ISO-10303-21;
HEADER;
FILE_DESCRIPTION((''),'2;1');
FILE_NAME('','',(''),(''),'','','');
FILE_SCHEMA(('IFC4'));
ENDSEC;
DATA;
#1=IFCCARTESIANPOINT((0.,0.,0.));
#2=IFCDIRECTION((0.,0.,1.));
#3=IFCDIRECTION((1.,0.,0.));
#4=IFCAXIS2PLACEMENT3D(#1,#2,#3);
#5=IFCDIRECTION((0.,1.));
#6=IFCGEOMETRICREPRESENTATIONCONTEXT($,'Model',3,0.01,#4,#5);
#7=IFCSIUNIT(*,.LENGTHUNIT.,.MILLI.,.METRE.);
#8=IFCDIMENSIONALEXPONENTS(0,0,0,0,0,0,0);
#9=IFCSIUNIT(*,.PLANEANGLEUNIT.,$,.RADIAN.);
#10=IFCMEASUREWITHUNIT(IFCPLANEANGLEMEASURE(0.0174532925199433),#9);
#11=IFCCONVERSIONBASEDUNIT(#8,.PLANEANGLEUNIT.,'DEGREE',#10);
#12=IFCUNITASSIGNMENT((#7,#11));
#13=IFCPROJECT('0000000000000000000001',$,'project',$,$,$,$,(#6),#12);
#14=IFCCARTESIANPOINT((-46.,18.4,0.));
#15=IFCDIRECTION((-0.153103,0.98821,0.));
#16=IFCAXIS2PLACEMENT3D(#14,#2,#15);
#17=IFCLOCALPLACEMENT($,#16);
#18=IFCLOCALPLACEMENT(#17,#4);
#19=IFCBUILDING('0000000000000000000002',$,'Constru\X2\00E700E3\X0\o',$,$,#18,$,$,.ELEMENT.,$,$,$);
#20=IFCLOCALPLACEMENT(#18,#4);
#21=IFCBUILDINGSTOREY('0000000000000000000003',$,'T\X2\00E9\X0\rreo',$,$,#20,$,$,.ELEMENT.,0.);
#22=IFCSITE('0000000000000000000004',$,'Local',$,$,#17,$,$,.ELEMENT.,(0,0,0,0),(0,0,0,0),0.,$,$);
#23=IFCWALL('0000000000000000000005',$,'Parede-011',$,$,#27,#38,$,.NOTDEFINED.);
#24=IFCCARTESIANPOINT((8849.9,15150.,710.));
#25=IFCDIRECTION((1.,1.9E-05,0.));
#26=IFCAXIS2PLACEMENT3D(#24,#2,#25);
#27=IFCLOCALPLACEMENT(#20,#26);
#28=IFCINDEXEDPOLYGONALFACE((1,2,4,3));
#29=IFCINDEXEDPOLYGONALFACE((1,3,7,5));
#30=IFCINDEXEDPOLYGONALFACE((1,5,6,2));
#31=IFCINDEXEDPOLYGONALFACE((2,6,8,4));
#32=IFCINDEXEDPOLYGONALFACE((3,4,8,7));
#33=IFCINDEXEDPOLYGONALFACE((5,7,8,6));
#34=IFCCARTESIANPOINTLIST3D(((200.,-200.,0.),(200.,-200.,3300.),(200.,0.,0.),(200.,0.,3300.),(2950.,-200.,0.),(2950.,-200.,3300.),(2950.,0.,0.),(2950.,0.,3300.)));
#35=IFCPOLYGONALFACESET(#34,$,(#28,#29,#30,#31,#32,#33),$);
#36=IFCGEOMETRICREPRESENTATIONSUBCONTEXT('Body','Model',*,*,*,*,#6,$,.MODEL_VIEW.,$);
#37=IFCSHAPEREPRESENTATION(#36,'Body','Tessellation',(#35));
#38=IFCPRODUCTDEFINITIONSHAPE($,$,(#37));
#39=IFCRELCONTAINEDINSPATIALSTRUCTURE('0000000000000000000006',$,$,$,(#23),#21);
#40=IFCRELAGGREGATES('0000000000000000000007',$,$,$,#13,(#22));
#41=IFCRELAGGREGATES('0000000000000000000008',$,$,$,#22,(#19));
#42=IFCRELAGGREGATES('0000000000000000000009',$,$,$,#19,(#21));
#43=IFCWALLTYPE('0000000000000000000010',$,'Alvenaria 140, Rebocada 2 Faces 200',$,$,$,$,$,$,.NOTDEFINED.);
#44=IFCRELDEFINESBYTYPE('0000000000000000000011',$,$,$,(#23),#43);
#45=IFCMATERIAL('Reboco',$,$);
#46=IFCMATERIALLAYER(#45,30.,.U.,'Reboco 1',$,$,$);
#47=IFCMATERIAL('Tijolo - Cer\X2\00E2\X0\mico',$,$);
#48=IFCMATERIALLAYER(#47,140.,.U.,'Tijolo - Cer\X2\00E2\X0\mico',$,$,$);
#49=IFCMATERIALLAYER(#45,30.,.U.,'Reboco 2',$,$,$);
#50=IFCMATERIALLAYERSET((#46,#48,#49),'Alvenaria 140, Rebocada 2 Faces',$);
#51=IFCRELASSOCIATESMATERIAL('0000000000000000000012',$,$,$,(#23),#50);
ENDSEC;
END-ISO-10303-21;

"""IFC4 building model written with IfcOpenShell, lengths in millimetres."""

from ifc_helpers import new_model, entity, si_unit, converted_unit, direction, frame, origin_with_axes, place, context, subcontext, project, spatial, line, indexed_curve, outline, extrude, material, layer, layer_set, layer_usage, type_object, element, save


model = new_model("IFC4")

# Units and contexts
model_context = context("Model", 3, precision=0.01, world=origin_with_axes(), true_north=direction((0.0, 1.0)))
body_context = subcontext(model_context, "Body", "Model", "MODEL_VIEW")
ifc_project = project(units=[si_unit("LENGTHUNIT", "METRE", prefix="MILLI"), converted_unit("PLANEANGLEUNIT", "DEGREE", entity("IfcPlaneAngleMeasure", 0.0174532925199433), si_unit("PLANEANGLEUNIT", "RADIAN"), dimensions=[0, 0, 0, 0, 0, 0, 0])], contexts=[model_context])

# Site, building, storey
site_placement = place(None, frame((-46.0, 18.4, 0.0), z_axis=(0.0, 0.0, 1.0), x_axis=(-0.153103, 0.98821, 0.0)))
site = spatial("IfcSite", under=ifc_project, at=site_placement, Name="Local", CompositionType="ELEMENT", RefLatitude=(0, 0, 0, 0), RefLongitude=(0, 0, 0, 0), RefElevation=0.0)
building_placement = place(site_placement, origin_with_axes())
building = spatial("IfcBuilding", under=site, at=building_placement, Name="Construção", CompositionType="ELEMENT")
storey_placement = place(building_placement, origin_with_axes())
storey = spatial("IfcBuildingStorey", under=building, at=storey_placement, Name="Térreo", CompositionType="ELEMENT", Elevation=0.0)

# Shared definitions
ifc_material_1 = material(Name="Reboco")
ifc_layer_1 = layer(ifc_material_1, 30.0, ventilated="UNKNOWN", Name="Reboco 1")
ifc_material_2 = material(Name="Tijolo - Cerâmico")
ifc_layer_2 = layer(ifc_material_2, 140.0, ventilated="UNKNOWN", Name="Tijolo - Cerâmico")
ifc_layer_3 = layer(ifc_material_1, 30.0, ventilated="UNKNOWN", Name="Reboco 2")
ifc_layer_set_1 = layer_set([ifc_layer_1, ifc_layer_2, ifc_layer_3], Name="Alvenaria 140, Rebocada 2 Faces")
wall_type_1 = type_object("IfcWallType", Name="Alvenaria 140, Rebocada 2 Faces 200", PredefinedType="NOTDEFINED")

# Wall
ifc_layer_usage_1 = layer_usage(ifc_layer_set_1, "AXIS2", "NEGATIVE", 0.0)
wall_1_placement = place(storey_placement, frame((8849.9, 15150.0, 710.0), z_axis=(0.0, 0.0, 1.0), x_axis=(1.0, 0.000019, 0.0)))
element("IfcWall", 1, at=wall_1_placement, inside=storey, type_object=wall_type_1, material=ifc_layer_usage_1, Name="Parede-011", PredefinedType="NOTDEFINED", context=body_context, shape_type="SweptSolid", body=[
    extrude(outline(indexed_curve([(200.0, -200.0), (2950.0, -200.0), (2950.0, 0.0), (200.0, 0.0)], segments=[line(1, 2, 3, 4, 1)])), origin_with_axes(), (0.0, 0.0, 1.0), 3300.0),
])

save(model, "model.ifc")
